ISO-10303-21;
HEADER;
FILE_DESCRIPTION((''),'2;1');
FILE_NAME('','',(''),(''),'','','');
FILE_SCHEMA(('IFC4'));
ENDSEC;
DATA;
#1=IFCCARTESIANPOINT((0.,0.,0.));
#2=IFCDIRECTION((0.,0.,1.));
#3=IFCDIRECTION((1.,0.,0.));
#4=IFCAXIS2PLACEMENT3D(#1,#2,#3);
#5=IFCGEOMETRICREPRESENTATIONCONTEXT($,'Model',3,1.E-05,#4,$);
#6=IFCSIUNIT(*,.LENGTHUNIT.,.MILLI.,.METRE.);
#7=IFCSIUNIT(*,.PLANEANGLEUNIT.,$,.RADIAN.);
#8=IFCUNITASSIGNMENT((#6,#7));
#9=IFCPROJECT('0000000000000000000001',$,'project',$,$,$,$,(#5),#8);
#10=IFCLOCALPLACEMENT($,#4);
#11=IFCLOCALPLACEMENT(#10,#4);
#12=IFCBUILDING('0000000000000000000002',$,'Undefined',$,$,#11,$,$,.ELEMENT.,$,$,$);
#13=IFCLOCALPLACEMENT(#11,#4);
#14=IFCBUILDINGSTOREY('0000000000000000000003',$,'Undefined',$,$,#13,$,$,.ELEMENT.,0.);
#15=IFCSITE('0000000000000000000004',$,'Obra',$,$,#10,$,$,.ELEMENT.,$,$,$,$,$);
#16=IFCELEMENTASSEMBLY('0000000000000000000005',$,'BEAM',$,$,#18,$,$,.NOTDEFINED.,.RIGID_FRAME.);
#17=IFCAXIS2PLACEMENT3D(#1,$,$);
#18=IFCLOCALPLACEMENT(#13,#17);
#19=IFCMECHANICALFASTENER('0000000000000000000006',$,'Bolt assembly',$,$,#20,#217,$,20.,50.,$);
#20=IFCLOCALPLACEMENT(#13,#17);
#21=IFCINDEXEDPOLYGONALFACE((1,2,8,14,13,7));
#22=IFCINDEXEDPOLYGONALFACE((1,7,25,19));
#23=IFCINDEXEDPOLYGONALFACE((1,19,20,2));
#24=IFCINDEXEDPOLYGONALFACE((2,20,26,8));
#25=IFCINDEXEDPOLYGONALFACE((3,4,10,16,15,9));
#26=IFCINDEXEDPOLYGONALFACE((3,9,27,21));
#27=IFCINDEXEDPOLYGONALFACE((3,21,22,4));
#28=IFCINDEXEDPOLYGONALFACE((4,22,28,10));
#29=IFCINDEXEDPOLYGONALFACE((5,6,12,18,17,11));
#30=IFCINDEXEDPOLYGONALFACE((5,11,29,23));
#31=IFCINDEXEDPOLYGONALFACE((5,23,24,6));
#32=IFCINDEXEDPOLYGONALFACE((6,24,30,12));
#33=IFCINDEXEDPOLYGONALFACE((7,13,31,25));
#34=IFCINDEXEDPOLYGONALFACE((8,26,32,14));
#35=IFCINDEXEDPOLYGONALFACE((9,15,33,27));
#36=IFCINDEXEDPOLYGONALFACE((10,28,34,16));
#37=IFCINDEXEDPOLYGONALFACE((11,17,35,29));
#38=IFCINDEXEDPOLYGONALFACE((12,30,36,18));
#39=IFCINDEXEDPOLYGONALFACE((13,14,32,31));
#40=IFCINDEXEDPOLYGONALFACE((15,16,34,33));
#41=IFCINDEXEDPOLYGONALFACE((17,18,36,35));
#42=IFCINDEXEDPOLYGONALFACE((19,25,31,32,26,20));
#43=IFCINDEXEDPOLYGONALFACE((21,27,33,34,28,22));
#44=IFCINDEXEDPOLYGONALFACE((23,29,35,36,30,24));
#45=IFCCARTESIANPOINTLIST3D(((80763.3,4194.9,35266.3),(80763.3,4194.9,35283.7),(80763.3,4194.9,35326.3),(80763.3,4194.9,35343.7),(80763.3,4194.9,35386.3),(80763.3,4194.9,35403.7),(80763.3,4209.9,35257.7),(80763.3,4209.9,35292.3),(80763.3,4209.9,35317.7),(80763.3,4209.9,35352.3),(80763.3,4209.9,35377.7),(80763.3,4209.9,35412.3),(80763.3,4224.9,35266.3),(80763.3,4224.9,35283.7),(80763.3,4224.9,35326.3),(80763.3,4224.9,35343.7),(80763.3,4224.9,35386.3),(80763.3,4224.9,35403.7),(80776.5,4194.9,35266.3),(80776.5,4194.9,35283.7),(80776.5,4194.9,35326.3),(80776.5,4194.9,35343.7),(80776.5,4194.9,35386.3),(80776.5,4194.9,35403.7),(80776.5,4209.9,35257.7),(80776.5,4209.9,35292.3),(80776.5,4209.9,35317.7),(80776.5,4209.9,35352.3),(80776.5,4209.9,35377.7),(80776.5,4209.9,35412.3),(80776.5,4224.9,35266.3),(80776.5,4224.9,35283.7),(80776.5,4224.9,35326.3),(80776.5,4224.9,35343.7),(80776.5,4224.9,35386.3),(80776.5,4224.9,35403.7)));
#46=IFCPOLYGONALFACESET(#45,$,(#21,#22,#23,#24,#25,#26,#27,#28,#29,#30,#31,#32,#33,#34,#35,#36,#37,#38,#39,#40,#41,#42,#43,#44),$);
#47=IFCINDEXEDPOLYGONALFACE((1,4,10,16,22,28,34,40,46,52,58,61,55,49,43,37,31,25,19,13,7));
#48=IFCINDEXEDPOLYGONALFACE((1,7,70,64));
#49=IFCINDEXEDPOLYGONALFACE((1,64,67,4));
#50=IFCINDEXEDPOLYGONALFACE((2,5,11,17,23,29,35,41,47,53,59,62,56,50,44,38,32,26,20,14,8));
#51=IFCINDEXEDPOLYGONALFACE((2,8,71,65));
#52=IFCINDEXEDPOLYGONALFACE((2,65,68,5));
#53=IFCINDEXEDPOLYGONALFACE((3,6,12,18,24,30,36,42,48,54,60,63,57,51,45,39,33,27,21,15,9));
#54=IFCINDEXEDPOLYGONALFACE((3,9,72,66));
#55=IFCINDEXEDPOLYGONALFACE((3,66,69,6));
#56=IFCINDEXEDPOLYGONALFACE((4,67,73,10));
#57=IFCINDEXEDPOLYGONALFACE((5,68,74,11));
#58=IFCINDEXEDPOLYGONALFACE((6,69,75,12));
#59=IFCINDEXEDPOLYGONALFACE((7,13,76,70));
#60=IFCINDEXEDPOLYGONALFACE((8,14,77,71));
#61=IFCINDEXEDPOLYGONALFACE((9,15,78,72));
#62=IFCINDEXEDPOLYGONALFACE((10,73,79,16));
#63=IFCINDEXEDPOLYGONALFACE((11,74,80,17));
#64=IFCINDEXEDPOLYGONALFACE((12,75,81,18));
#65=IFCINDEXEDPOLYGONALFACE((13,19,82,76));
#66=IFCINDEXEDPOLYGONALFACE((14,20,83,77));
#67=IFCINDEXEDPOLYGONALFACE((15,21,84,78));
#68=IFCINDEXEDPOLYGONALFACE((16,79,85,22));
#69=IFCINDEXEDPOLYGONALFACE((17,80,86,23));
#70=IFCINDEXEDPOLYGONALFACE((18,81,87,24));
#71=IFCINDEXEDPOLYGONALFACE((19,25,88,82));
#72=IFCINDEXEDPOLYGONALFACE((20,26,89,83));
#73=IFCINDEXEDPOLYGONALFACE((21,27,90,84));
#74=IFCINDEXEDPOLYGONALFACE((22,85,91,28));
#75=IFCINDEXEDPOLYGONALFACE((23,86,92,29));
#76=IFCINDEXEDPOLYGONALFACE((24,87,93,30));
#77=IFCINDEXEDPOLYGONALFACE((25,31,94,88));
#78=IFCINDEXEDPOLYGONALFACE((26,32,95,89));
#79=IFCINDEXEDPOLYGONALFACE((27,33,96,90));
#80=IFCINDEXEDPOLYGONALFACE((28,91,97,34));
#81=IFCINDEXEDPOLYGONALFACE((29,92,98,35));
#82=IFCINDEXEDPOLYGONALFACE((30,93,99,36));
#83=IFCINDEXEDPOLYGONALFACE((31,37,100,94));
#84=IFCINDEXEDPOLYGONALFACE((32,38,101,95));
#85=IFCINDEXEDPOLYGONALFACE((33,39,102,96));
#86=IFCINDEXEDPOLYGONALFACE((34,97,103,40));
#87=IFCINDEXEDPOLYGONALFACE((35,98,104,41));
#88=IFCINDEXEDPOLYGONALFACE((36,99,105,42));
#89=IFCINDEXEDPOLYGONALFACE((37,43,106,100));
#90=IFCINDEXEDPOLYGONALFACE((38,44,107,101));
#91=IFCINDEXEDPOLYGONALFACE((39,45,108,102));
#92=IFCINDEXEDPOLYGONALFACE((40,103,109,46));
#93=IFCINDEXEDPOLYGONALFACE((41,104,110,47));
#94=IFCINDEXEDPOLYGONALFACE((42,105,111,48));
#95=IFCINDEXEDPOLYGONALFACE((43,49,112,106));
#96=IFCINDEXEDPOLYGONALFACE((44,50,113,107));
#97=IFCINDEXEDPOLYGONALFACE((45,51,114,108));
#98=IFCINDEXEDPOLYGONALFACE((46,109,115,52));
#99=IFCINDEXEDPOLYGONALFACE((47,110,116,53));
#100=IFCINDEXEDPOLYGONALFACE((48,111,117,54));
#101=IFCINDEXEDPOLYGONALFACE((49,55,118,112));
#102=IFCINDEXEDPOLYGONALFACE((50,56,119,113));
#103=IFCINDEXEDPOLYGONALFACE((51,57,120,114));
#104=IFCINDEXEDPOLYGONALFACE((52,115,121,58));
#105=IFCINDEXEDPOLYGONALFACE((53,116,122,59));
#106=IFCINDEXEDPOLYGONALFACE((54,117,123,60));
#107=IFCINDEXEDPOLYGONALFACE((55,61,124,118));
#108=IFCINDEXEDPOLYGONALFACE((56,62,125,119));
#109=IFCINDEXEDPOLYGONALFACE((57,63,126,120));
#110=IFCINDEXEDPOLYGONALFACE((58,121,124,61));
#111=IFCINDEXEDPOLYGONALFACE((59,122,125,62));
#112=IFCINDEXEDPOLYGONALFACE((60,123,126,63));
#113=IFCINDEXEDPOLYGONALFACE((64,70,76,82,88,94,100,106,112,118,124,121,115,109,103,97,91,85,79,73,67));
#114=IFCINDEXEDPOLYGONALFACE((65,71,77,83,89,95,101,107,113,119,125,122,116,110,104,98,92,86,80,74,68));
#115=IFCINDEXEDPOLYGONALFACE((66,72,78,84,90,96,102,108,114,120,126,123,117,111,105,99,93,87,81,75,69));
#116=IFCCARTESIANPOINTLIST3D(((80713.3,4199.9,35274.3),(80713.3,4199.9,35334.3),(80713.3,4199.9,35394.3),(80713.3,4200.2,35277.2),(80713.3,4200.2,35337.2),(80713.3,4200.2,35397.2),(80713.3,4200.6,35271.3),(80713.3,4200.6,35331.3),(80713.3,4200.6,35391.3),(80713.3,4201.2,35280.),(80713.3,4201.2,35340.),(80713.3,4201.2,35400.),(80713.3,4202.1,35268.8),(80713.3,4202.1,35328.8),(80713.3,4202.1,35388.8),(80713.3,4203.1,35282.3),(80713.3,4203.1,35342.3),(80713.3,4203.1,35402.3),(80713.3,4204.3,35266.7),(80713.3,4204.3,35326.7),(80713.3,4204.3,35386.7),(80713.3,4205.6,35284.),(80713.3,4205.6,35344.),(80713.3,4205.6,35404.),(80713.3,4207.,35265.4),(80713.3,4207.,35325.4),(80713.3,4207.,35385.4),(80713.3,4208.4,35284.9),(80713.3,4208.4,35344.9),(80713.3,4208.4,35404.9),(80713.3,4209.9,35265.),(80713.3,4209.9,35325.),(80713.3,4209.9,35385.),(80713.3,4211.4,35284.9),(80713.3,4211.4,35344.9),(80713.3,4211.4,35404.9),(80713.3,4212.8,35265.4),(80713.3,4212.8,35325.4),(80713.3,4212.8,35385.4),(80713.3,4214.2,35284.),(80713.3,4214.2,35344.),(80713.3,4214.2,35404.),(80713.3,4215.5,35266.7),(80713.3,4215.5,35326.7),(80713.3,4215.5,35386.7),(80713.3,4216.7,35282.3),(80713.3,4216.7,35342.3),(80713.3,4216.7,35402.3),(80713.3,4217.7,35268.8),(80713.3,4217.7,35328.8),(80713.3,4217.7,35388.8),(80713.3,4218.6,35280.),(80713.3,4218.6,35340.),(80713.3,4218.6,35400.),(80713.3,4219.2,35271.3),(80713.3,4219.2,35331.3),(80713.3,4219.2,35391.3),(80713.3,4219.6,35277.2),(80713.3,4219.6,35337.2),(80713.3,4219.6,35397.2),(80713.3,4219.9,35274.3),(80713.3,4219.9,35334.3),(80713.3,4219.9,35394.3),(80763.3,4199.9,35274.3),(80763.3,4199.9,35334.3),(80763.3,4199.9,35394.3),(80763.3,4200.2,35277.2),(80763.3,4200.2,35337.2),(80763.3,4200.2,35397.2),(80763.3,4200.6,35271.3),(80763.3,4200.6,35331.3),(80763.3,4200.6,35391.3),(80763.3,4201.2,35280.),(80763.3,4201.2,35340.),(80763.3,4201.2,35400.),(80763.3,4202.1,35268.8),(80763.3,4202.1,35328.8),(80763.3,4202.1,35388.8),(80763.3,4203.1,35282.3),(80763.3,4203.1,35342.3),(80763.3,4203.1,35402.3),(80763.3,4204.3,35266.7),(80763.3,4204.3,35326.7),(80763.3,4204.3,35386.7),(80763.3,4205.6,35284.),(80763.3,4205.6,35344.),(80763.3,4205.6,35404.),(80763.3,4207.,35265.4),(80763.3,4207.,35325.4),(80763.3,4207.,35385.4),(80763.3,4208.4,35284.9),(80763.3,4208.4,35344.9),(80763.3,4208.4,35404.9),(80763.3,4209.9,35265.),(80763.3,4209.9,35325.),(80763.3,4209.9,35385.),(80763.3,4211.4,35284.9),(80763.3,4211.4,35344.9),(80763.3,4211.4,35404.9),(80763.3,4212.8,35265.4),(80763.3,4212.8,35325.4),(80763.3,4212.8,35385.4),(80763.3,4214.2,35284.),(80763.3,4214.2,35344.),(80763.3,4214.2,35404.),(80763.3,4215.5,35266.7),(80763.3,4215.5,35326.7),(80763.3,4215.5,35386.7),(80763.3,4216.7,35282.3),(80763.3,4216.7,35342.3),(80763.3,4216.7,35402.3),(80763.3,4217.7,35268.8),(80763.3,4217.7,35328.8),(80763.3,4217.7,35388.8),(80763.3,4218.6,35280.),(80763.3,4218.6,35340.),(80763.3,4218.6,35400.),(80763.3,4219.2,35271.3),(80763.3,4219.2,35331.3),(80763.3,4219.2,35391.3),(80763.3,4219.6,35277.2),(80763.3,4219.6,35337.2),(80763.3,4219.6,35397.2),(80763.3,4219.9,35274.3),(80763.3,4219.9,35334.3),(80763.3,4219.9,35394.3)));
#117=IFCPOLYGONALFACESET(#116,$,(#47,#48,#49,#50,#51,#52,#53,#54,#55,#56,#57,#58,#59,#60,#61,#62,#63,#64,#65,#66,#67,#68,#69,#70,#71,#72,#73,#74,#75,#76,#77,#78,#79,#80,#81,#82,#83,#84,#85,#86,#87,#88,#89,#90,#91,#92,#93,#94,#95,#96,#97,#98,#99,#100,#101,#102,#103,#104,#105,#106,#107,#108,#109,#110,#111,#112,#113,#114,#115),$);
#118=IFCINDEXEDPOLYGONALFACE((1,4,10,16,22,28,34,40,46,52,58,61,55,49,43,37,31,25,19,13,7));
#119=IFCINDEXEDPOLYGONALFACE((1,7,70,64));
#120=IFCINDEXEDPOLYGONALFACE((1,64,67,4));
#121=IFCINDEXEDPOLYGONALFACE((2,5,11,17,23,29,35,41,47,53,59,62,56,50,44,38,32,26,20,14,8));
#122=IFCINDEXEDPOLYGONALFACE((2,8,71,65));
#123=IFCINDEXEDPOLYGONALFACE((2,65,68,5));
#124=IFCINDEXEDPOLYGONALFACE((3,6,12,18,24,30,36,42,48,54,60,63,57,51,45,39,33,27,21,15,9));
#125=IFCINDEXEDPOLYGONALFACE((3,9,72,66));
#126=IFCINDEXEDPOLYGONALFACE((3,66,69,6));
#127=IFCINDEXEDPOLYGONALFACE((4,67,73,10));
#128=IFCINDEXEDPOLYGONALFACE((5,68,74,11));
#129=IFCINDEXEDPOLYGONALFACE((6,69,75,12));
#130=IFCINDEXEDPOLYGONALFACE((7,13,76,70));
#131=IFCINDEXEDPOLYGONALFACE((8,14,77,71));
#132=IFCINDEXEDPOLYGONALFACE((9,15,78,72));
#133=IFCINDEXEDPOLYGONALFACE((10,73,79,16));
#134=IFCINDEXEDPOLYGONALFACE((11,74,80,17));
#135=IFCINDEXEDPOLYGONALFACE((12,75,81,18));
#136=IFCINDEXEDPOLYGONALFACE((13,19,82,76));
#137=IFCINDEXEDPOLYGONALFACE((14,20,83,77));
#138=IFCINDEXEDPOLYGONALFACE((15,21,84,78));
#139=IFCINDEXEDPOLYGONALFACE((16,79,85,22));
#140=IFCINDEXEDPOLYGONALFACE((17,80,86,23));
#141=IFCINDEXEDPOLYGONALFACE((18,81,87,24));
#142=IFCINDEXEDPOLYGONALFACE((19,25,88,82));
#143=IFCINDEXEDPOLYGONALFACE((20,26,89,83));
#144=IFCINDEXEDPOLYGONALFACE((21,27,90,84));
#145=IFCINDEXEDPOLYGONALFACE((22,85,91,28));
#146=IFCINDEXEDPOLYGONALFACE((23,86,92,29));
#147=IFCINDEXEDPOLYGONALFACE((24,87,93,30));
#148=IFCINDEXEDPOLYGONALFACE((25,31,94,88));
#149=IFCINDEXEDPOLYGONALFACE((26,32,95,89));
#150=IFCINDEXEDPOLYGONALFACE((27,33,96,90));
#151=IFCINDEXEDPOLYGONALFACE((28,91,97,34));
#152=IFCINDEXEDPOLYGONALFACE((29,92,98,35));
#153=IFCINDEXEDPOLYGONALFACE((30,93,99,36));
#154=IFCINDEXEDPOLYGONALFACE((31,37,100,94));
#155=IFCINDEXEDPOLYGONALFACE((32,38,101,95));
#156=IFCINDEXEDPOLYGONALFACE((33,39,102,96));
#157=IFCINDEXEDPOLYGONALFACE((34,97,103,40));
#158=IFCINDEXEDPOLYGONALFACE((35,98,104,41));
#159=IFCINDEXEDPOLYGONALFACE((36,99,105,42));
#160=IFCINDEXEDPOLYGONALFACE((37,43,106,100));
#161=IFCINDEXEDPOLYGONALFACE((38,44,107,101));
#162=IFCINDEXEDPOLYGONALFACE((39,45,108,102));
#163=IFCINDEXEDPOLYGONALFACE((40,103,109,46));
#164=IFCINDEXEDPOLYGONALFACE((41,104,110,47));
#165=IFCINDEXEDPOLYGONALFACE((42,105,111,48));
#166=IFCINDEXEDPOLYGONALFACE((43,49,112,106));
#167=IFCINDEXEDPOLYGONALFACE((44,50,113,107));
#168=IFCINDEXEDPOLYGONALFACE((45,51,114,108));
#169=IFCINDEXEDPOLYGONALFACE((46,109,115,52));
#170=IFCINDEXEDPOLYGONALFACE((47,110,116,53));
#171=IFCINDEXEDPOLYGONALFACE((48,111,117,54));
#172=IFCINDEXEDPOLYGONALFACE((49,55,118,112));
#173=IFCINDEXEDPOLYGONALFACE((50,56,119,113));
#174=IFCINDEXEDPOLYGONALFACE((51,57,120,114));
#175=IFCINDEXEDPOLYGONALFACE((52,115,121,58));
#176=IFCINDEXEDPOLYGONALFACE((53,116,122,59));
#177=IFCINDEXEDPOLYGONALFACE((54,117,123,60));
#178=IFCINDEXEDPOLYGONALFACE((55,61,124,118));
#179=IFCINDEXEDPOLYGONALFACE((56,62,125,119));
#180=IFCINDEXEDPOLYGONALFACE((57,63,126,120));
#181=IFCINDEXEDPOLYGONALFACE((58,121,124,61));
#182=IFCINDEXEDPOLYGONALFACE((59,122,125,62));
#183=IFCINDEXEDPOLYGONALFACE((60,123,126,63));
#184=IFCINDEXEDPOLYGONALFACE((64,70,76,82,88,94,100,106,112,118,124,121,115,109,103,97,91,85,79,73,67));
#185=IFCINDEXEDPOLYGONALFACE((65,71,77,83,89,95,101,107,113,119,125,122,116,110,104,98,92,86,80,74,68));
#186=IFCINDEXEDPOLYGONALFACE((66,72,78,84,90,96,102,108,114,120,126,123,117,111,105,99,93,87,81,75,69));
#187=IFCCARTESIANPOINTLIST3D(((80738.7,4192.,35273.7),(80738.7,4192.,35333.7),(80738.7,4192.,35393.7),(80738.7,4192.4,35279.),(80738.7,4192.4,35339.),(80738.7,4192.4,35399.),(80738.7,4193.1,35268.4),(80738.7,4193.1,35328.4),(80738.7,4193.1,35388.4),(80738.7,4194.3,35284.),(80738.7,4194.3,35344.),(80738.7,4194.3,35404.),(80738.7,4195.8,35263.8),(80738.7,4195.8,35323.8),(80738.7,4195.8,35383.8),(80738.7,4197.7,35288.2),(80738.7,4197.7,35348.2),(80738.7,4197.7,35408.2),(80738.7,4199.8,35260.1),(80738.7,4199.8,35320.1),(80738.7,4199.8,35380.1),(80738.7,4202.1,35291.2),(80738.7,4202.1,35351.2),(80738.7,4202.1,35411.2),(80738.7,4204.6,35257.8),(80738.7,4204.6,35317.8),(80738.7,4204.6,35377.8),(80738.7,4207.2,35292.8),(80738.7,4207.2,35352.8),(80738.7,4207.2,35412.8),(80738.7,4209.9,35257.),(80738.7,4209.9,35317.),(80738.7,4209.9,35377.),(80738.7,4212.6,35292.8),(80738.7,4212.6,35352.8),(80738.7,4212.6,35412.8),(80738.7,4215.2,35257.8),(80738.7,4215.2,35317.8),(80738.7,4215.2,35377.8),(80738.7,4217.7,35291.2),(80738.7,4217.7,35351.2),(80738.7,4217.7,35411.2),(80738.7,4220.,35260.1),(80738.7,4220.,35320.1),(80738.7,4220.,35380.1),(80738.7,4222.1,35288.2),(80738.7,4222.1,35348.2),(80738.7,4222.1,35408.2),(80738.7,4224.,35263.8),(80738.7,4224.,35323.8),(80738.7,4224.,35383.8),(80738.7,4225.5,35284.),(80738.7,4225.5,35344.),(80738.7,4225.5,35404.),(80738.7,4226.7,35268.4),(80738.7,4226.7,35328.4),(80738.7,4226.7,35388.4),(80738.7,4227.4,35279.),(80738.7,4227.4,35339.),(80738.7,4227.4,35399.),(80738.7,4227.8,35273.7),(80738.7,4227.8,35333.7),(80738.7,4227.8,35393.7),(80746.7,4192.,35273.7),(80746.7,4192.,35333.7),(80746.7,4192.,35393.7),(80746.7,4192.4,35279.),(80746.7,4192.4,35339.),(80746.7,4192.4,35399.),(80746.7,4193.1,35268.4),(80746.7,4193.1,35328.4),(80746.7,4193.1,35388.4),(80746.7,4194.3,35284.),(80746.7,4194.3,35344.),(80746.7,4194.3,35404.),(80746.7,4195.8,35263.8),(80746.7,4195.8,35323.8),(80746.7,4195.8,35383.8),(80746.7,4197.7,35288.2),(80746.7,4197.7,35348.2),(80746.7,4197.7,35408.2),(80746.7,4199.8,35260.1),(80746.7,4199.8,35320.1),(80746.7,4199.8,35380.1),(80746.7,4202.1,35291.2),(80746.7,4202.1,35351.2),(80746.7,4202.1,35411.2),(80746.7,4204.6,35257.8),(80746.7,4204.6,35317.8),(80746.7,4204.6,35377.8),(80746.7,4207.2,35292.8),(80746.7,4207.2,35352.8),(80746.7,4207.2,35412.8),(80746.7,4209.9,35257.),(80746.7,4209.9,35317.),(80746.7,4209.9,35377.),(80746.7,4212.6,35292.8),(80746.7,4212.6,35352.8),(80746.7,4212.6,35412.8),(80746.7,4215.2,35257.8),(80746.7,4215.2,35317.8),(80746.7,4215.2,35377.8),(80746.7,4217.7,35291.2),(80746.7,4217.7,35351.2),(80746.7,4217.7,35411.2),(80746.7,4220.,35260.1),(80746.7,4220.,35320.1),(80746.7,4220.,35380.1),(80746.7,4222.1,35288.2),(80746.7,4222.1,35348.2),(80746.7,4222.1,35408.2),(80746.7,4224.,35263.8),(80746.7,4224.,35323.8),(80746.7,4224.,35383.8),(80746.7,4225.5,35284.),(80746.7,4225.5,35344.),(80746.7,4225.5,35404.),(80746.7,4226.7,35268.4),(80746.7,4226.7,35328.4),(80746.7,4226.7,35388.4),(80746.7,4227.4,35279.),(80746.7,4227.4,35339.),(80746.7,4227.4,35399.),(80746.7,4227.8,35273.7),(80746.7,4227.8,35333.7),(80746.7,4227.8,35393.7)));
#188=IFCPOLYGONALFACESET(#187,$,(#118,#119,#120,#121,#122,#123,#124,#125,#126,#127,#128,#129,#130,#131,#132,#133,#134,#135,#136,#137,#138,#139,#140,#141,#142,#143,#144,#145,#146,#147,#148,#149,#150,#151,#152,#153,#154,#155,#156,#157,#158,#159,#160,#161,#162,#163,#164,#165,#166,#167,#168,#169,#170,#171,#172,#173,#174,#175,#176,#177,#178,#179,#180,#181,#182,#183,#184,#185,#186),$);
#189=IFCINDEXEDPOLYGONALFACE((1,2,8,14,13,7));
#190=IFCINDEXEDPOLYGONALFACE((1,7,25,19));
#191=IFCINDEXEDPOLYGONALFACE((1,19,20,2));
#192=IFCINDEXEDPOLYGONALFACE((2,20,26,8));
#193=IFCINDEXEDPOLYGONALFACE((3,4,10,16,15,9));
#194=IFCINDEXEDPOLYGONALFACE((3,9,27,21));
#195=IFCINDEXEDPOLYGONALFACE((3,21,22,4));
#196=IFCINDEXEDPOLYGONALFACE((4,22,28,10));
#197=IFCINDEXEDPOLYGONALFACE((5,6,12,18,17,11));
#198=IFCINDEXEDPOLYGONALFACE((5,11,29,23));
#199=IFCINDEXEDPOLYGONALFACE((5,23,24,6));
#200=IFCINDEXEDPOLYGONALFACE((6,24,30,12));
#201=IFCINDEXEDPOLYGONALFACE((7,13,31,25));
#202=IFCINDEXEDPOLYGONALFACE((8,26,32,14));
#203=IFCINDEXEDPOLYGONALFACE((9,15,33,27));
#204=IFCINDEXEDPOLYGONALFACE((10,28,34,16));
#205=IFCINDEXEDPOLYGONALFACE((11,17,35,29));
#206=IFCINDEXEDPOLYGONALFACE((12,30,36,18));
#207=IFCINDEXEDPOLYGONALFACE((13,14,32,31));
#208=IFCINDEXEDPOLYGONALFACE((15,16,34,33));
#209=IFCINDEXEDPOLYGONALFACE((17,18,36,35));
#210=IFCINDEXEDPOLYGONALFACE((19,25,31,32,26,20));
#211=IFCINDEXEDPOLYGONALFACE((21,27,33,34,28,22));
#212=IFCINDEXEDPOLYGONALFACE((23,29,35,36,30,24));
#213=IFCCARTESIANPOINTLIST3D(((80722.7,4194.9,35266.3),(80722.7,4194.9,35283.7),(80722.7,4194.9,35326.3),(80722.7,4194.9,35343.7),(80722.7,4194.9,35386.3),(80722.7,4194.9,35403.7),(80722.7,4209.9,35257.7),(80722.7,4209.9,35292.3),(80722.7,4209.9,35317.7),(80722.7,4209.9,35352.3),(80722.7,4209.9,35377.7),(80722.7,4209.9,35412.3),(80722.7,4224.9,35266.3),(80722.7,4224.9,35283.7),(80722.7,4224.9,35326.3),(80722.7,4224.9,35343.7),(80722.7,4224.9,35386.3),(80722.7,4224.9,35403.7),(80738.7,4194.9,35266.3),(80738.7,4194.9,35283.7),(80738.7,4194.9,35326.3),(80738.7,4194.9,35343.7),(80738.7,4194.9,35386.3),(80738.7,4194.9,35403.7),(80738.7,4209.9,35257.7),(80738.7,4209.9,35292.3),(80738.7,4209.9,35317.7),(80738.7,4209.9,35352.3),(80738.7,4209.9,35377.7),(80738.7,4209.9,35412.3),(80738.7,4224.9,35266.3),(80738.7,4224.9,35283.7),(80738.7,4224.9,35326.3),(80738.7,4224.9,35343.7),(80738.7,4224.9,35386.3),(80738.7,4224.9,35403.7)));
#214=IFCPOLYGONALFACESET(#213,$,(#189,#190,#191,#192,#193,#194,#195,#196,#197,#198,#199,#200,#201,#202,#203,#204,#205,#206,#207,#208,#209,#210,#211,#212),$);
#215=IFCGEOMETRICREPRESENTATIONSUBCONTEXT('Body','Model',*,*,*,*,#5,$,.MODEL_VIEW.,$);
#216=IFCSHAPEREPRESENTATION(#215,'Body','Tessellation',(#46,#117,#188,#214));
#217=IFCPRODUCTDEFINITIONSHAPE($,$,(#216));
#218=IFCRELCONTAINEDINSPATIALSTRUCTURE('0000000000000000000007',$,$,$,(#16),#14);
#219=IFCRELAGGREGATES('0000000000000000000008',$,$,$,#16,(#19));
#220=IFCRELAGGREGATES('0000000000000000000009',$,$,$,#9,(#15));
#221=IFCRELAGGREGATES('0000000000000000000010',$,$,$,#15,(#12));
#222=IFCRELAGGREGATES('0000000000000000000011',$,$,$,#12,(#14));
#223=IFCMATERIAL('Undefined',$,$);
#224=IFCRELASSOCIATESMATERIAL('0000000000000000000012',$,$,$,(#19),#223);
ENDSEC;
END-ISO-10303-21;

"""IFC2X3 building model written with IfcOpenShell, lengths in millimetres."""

from ifc_helpers import new_model, si_unit, frame, origin_with_axes, origin_2d_with_axis, place, context, subcontext, project, spatial, polyline, circle, outline, extrude, source, transform, mapped, material, element, aggregate, save


model = new_model("IFC2X3")

# Units and contexts
model_context = context("Model", 3, precision=1e-05, world=origin_with_axes())
body_context = subcontext(model_context, "Body", "Model", "MODEL_VIEW")
ifc_project = project(units=[si_unit("LENGTHUNIT", "METRE", prefix="MILLI"), si_unit("PLANEANGLEUNIT", "RADIAN")], contexts=[model_context])

# Site, building, storey
site_placement = place(None, origin_with_axes())
site = spatial("IfcSite", under=ifc_project, at=site_placement, Name="Obra", CompositionType="ELEMENT")
building_placement = place(site_placement, origin_with_axes())
building = spatial("IfcBuilding", under=site, at=building_placement, Name="Undefined", CompositionType="ELEMENT")
storey_placement = place(building_placement, origin_with_axes())
storey = spatial("IfcBuildingStorey", under=building, at=storey_placement, Name="Undefined", CompositionType="ELEMENT", Elevation=0.0)

# Element assembly, mechanical fastener
assembly_1_placement = place(storey_placement, origin_with_axes())
assembly_1 = element("IfcElementAssembly", 1, at=assembly_1_placement, inside=storey, Name="BEAM", AssemblyPlace="NOTDEFINED", PredefinedType="RIGID_FRAME")
ifc_material_1 = material(Name="Undefined")
shared_shape_1 = source(origin_with_axes(), body_context, "Body", "SweptSolid", [
    extrude(outline(polyline([(17.3, 0.0), (8.7, 15.0), (-8.7, 15.0), (-17.3, 0.0), (-8.7, -15.0), (8.7, -15.0), (17.3, 0.0)])), frame((0.0, -26.5, 0.0), z_axis=(0.0, 1.0, 0.0), x_axis=(1.0, 0.0, 0.0)), (0.0, 0.0, 1.0), 13.2),
    extrude(circle(Radius=10.0, at=origin_2d_with_axis()), frame((0.0, -13.3, 0.0), z_axis=(0.0, 1.0, 0.0), x_axis=(1.0, 0.0, 0.0)), (0.0, 0.0, 1.0), 50.0),
    extrude(circle(Radius=18.0, at=origin_2d_with_axis()), frame((0.0, 3.3, 0.0), z_axis=(0.0, 1.0, 0.0), x_axis=(1.0, 0.0, 0.0)), (0.0, 0.0, 1.0), 8.0),
    extrude(outline(polyline([(17.3, 0.0), (8.7, 15.0), (-8.7, 15.0), (-17.3, 0.0), (-8.7, -15.0), (8.7, -15.0), (17.3, 0.0)])), frame((0.0, 11.3, 0.0), z_axis=(0.0, 1.0, 0.0), x_axis=(1.0, 0.0, 0.0)), (0.0, 0.0, 1.0), 16.0),
])
mechanical_fastener_1_placement = place(assembly_1_placement, frame((80750.0, 4159.9, 35435.0), z_axis=(0.0, 1.0, 0.0), x_axis=(0.0, 0.0, -1.0)))
mechanical_fastener_1 = element("IfcMechanicalFastener", 2, at=mechanical_fastener_1_placement, material=ifc_material_1, Name="Bolt assembly", NominalDiameter=20.0, NominalLength=50.0, context=body_context, shape_type="MappedRepresentation", body=[
    mapped(shared_shape_1, transform((40.0, 0.0, 50.0))),
    mapped(shared_shape_1, transform((100.0, 0.0, 50.0))),
    mapped(shared_shape_1, transform((160.0, 0.0, 50.0))),
])

aggregate(assembly_1, [mechanical_fastener_1])

save(model, "model.ifc")
